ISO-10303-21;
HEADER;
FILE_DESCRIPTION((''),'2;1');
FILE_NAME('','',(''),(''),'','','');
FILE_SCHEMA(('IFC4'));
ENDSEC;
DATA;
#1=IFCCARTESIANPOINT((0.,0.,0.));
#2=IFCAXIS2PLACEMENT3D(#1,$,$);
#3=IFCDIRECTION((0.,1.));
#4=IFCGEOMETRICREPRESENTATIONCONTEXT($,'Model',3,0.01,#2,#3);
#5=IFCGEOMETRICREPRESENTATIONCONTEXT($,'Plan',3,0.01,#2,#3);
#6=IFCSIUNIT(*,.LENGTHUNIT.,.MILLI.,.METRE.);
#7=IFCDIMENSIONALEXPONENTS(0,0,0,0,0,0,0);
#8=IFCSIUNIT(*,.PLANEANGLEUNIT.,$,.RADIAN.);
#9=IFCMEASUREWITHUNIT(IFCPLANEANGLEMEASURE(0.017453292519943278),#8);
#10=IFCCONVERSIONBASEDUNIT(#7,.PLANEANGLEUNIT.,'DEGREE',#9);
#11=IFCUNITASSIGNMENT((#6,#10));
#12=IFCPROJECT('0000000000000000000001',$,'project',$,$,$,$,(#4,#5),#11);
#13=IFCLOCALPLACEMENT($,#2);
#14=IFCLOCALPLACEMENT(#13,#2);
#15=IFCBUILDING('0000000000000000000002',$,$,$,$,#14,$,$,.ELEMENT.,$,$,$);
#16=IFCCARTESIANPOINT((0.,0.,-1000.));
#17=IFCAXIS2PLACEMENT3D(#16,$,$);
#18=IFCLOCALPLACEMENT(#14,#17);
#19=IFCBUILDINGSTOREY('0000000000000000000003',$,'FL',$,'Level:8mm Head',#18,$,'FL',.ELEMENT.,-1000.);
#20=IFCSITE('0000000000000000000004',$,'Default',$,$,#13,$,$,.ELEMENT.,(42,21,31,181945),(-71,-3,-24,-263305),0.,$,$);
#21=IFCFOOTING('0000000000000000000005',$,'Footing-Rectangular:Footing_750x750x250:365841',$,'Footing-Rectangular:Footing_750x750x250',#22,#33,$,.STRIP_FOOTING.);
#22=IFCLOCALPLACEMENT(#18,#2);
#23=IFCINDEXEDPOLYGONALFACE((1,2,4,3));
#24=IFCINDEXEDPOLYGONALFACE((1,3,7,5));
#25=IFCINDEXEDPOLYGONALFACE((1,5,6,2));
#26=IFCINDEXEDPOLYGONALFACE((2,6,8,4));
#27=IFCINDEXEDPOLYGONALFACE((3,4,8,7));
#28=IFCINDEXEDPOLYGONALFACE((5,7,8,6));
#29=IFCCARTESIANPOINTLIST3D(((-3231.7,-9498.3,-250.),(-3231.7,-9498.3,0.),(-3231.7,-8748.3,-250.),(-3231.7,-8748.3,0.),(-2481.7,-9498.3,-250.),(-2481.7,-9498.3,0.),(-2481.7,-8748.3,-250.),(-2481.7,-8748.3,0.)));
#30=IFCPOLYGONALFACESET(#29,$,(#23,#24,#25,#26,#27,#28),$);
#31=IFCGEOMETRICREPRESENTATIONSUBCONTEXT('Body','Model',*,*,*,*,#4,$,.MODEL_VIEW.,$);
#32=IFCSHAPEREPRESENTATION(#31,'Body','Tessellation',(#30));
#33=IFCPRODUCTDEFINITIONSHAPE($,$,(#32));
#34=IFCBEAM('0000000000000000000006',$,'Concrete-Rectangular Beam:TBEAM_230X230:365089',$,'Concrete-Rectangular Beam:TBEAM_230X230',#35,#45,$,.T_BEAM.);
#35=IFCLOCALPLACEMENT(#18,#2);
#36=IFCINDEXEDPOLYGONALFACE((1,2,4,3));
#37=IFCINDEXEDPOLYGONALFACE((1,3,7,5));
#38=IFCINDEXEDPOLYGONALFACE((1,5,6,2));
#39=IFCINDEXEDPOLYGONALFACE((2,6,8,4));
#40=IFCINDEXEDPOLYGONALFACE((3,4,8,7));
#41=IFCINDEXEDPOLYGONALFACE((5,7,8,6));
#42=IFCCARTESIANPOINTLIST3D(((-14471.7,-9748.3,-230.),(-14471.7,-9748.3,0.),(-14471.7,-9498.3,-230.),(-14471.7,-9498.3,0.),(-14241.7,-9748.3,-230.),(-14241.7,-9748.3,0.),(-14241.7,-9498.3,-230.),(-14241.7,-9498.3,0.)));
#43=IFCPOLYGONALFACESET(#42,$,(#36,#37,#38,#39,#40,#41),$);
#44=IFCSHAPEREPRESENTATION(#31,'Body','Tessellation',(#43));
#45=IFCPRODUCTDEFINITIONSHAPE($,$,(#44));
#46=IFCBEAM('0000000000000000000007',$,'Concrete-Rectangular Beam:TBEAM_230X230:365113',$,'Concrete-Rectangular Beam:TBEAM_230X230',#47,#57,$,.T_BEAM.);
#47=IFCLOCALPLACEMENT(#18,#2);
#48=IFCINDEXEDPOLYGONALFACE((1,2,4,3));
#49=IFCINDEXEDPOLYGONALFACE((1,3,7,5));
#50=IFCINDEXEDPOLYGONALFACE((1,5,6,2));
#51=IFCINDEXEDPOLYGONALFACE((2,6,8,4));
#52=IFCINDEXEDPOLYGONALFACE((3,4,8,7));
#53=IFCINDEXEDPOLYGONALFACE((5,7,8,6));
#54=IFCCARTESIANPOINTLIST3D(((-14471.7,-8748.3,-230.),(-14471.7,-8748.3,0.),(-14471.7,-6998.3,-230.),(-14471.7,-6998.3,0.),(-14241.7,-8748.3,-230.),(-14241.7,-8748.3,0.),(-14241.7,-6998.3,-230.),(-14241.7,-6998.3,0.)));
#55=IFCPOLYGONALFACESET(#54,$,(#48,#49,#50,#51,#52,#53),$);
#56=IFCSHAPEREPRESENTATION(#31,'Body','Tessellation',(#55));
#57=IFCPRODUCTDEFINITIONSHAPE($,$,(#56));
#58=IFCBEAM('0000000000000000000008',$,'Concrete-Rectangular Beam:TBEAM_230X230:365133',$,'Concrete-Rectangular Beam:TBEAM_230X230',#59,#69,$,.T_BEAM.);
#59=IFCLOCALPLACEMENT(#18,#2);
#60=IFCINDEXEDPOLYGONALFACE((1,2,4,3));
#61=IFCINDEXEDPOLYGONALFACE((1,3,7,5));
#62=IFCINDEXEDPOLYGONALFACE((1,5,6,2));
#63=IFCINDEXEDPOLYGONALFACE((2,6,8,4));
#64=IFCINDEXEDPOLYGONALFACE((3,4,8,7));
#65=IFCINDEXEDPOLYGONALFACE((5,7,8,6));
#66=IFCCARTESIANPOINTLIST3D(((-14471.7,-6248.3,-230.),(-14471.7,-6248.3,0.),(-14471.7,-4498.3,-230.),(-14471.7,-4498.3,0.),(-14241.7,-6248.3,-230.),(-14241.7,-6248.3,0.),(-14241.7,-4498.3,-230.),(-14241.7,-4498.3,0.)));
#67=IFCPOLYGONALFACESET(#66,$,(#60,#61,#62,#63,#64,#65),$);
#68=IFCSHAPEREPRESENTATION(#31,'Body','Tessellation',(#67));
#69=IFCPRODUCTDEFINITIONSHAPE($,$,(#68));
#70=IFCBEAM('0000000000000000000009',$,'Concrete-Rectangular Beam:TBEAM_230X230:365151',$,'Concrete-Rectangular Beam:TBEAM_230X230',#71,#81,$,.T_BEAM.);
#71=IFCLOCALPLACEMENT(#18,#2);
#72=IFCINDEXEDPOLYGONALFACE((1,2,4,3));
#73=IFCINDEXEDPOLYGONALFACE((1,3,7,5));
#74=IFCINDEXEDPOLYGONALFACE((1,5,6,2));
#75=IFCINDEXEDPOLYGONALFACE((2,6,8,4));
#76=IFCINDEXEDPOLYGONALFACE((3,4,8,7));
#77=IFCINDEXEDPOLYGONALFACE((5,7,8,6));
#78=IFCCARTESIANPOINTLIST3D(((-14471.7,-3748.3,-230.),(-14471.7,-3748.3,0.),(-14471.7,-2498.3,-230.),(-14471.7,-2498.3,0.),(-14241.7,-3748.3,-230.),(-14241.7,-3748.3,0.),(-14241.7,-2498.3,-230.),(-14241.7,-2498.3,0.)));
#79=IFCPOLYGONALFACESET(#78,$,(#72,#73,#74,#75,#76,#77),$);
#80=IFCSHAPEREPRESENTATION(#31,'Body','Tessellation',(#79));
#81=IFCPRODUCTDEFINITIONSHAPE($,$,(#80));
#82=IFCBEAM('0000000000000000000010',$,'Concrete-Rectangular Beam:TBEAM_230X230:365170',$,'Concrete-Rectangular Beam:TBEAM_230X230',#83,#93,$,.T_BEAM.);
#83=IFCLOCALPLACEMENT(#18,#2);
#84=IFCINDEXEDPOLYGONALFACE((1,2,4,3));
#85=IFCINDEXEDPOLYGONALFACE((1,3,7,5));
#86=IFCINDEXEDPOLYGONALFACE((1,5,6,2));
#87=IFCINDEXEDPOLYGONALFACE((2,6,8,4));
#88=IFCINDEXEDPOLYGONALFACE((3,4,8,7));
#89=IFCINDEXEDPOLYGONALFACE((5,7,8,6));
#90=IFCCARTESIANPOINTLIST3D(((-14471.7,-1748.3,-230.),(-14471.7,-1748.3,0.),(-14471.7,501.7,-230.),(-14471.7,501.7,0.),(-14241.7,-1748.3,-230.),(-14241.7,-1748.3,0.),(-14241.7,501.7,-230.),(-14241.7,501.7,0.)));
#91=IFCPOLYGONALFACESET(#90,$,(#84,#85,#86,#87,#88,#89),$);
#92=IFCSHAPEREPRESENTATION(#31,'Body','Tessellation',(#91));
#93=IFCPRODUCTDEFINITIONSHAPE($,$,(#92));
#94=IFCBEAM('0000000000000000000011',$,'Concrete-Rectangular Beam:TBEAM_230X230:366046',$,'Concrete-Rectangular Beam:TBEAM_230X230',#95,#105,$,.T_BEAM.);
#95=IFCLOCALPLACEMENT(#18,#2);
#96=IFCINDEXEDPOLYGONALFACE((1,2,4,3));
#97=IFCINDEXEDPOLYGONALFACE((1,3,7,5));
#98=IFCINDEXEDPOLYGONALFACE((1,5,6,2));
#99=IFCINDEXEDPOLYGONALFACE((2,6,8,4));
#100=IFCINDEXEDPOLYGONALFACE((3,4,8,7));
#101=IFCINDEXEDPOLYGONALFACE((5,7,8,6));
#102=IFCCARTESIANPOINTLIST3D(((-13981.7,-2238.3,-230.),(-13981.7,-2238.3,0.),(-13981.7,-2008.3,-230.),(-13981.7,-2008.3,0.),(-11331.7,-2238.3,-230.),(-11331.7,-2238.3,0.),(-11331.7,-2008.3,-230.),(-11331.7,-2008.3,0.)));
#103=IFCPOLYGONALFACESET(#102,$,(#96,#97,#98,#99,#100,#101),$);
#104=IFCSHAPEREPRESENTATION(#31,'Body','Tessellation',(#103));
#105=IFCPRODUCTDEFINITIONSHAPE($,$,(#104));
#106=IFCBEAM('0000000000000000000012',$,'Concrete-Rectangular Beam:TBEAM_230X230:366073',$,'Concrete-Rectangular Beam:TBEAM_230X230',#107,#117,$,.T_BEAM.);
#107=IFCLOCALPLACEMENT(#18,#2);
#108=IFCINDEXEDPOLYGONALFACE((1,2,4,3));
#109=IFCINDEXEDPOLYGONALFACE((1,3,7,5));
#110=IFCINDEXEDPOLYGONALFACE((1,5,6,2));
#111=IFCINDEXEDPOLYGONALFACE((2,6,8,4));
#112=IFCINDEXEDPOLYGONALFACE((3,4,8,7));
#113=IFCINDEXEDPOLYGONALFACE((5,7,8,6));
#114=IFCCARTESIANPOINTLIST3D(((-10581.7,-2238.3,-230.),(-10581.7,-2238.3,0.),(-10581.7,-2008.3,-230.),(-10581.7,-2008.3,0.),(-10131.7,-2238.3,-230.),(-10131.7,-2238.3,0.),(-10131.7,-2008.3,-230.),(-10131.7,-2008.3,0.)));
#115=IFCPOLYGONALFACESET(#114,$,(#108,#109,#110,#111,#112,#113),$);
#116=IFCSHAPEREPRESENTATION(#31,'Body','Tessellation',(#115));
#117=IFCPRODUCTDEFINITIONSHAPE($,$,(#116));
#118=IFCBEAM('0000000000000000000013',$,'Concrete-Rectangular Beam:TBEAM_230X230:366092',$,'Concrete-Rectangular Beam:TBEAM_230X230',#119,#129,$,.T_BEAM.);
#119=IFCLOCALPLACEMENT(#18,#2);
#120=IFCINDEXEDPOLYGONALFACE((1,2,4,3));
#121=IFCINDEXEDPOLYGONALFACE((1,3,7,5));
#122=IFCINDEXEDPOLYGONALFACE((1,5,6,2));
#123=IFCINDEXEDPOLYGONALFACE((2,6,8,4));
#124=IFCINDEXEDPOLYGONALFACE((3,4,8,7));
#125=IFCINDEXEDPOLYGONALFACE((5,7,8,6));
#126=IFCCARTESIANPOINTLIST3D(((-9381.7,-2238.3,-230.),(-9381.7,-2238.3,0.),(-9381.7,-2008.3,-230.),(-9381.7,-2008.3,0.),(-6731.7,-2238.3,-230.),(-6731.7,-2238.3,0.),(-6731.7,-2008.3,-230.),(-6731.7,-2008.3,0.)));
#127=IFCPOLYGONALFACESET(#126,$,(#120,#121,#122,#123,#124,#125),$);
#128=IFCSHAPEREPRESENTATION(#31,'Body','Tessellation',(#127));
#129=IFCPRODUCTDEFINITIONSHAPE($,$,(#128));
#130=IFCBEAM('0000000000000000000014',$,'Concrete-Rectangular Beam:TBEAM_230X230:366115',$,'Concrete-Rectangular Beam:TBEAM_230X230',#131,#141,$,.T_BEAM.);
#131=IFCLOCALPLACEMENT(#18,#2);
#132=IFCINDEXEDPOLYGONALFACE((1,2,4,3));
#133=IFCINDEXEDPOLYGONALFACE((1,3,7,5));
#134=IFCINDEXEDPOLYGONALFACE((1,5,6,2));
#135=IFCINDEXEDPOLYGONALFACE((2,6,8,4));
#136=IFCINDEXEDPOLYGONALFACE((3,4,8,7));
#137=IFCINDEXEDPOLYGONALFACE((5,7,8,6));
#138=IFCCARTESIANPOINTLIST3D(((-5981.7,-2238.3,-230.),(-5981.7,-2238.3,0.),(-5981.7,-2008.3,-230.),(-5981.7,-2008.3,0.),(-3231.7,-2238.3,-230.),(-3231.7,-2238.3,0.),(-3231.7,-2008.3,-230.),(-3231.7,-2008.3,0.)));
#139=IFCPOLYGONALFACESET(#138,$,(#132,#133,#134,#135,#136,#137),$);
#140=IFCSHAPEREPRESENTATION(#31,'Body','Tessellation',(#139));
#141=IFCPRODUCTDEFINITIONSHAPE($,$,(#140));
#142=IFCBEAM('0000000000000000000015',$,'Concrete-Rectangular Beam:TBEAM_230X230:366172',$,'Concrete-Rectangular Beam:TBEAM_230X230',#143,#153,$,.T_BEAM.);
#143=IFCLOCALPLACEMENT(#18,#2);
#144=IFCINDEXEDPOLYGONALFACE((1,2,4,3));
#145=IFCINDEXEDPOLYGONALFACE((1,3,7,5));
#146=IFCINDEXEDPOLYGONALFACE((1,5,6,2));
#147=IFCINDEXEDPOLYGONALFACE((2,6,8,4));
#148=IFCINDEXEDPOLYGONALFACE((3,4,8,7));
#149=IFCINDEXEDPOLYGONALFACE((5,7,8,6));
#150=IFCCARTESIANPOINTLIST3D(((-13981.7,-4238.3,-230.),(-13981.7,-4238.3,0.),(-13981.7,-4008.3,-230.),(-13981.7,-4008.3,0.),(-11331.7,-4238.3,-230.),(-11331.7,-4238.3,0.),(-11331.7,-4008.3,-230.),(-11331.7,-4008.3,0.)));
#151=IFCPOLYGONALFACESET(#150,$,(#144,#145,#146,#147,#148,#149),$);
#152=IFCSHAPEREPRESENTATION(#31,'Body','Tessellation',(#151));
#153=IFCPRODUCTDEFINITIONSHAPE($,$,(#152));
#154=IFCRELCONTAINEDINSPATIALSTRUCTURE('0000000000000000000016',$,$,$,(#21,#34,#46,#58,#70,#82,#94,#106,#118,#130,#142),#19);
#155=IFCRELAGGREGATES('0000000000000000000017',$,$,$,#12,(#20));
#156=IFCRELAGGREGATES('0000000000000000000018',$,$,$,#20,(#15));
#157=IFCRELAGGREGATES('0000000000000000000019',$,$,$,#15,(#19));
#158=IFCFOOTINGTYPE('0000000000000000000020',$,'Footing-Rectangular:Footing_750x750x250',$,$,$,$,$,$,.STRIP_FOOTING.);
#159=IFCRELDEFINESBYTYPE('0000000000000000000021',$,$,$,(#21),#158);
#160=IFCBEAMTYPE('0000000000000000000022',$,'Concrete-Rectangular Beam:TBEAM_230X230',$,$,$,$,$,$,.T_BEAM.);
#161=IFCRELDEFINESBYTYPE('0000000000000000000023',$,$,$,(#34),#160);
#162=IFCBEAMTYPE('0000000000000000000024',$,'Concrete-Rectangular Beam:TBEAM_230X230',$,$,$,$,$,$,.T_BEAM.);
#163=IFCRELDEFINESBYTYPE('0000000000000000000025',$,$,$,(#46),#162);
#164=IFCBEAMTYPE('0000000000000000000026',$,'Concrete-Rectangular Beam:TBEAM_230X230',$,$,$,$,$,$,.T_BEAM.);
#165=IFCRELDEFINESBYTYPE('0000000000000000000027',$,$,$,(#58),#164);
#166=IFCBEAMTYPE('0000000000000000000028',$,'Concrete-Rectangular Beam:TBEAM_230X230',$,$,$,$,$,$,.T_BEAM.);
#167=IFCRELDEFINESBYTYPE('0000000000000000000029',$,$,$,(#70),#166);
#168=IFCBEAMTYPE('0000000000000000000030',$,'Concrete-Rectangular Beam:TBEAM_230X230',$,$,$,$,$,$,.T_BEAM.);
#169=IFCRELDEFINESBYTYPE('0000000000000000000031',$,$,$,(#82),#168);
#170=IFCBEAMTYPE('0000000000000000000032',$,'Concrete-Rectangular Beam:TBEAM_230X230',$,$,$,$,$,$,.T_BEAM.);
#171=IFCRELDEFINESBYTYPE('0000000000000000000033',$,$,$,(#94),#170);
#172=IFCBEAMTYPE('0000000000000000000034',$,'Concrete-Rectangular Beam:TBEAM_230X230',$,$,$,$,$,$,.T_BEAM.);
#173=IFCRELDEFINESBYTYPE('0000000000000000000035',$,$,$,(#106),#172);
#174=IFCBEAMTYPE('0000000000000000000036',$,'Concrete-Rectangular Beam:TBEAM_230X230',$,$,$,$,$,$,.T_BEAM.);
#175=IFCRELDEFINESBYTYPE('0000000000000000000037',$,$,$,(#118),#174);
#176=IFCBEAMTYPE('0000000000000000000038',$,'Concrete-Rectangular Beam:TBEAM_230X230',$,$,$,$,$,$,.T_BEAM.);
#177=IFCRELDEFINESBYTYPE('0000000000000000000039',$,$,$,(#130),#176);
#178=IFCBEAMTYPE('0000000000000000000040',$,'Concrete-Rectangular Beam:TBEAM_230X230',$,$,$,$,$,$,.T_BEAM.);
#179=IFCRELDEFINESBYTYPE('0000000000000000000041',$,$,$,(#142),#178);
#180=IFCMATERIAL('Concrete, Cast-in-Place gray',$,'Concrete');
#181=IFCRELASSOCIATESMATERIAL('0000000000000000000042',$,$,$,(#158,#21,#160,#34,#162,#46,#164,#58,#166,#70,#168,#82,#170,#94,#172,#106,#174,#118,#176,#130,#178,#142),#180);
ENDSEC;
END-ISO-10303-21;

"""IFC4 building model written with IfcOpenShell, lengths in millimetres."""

from ifc_helpers import new_model, entity, si_unit, converted_unit, direction, frame, origin, place, context, subcontext, project, spatial, indexed_curve, outline, extrude, source, transform, mapped, material, type_object, type_shapes, element, save


model = new_model("IFC4")

# Units and contexts
model_context = context("Model", 3, precision=0.01, world=origin(), true_north=direction((0.0, 1.0)))
plan_context = context("Plan", 3, precision=0.01, world=origin(), true_north=direction((0.0, 1.0)))
body_context = subcontext(model_context, "Body", "Model", "MODEL_VIEW")
ifc_project = project(units=[si_unit("LENGTHUNIT", "METRE", prefix="MILLI"), converted_unit("PLANEANGLEUNIT", "DEGREE", entity("IfcPlaneAngleMeasure", 0.017453292519943278), si_unit("PLANEANGLEUNIT", "RADIAN"), dimensions=[0, 0, 0, 0, 0, 0, 0])], contexts=[model_context, plan_context])

# Site, building, storey
site_placement = place(None, origin())
site = spatial("IfcSite", under=ifc_project, at=site_placement, Name="Default", CompositionType="ELEMENT", RefLatitude=(42, 21, 31, 181945), RefLongitude=(-71, -3, -24, -263305), RefElevation=0.0)
building_placement = place(site_placement, origin())
building = spatial("IfcBuilding", under=site, at=building_placement, CompositionType="ELEMENT")
storey_placement = place(building_placement, frame((0.0, 0.0, -1000.0)))
storey = spatial("IfcBuildingStorey", under=building, at=storey_placement, Name="FL", ObjectType="Level:8mm Head", LongName="FL", CompositionType="ELEMENT", Elevation=-1000.0)

# Footing
ifc_material = material(Name="Concrete, Cast-in-Place gray", Category="Concrete")
footing_type = type_object("IfcFootingType", Name="Footing-Rectangular:Footing_750x750x250", PredefinedType="STRIP_FOOTING", material=ifc_material)
shared_shape_1 = source(origin(), body_context, "Body", "SweptSolid", [
    extrude(outline(indexed_curve([(-375.0, -375.0), (375.0, -375.0), (375.0, 375.0), (-375.0, 375.0), (-375.0, -375.0)], self_intersect=False)), frame((-2856.7, -9123.3, -1250.0), z_axis=(0.0, 0.0, 1.0), x_axis=(-1.0, 0.0, 0.0)), (0.0, 0.0, 1.0), 250.0),
])
type_shapes(footing_type, [shared_shape_1])
footing_placement = place(storey_placement, frame((0.0, 0.0, 1000.0)))
element("IfcFooting", 1, at=footing_placement, inside=storey, type_object=footing_type, material=ifc_material, Name="Footing-Rectangular:Footing_750x750x250:365841", ObjectType="Footing-Rectangular:Footing_750x750x250", PredefinedType="STRIP_FOOTING", context=body_context, shape_type="MappedRepresentation", body=[
    mapped(shared_shape_1, transform((0.0, 0.0, 0.0), scale=1.0)),
])

# Beams
beam_type_1 = type_object("IfcBeamType", Name="Concrete-Rectangular Beam:TBEAM_230X230", PredefinedType="T_BEAM", material=ifc_material)
shared_shape_2 = source(origin(), body_context, "Body", "SweptSolid", [
    extrude(outline(indexed_curve([(-115.0, -115.0), (115.0, -115.0), (115.0, 115.0), (-115.0, 115.0), (-115.0, -115.0)], self_intersect=False)), frame((-14356.7, -9748.3, -1115.0), z_axis=(0.0, 1.0, 0.0), x_axis=(-1.0, 0.0, 0.0)), (0.0, 0.0, 1.0), 250.0),
])
type_shapes(beam_type_1, [shared_shape_2])
beam_1_placement = place(storey_placement, frame((0.0, 0.0, 1000.0)))
element("IfcBeam", 2, at=beam_1_placement, inside=storey, type_object=beam_type_1, material=ifc_material, Name="Concrete-Rectangular Beam:TBEAM_230X230:365089", ObjectType="Concrete-Rectangular Beam:TBEAM_230X230", PredefinedType="T_BEAM", context=body_context, shape_type="MappedRepresentation", body=[
    mapped(shared_shape_2, transform((0.0, 0.0, 0.0), scale=1.0)),
])
beam_type_2 = type_object("IfcBeamType", Name="Concrete-Rectangular Beam:TBEAM_230X230", PredefinedType="T_BEAM", material=ifc_material)
shared_shape_3 = source(origin(), body_context, "Body", "SweptSolid", [
    extrude(outline(indexed_curve([(-115.0, -115.0), (115.0, -115.0), (115.0, 115.0), (-115.0, 115.0), (-115.0, -115.0)], self_intersect=False)), frame((-14356.7, -8748.3, -1115.0), z_axis=(0.0, 1.0, 0.0), x_axis=(-1.0, 0.0, 0.0)), (0.0, 0.0, 1.0), 1750.0),
])
type_shapes(beam_type_2, [shared_shape_3])
beam_2_placement = place(storey_placement, frame((0.0, 0.0, 1000.0)))
element("IfcBeam", 3, at=beam_2_placement, inside=storey, type_object=beam_type_2, material=ifc_material, Name="Concrete-Rectangular Beam:TBEAM_230X230:365113", ObjectType="Concrete-Rectangular Beam:TBEAM_230X230", PredefinedType="T_BEAM", context=body_context, shape_type="MappedRepresentation", body=[
    mapped(shared_shape_3, transform((0.0, 0.0, 0.0), scale=1.0)),
])
beam_type_3 = type_object("IfcBeamType", Name="Concrete-Rectangular Beam:TBEAM_230X230", PredefinedType="T_BEAM", material=ifc_material)
shared_shape_4 = source(origin(), body_context, "Body", "SweptSolid", [
    extrude(outline(indexed_curve([(-115.0, -115.0), (115.0, -115.0), (115.0, 115.0), (-115.0, 115.0), (-115.0, -115.0)], self_intersect=False)), frame((-14356.7, -6248.3, -1115.0), z_axis=(0.0, 1.0, 0.0), x_axis=(-1.0, 0.0, 0.0)), (0.0, 0.0, 1.0), 1750.0),
])
type_shapes(beam_type_3, [shared_shape_4])
beam_3_placement = place(storey_placement, frame((0.0, 0.0, 1000.0)))
element("IfcBeam", 4, at=beam_3_placement, inside=storey, type_object=beam_type_3, material=ifc_material, Name="Concrete-Rectangular Beam:TBEAM_230X230:365133", ObjectType="Concrete-Rectangular Beam:TBEAM_230X230", PredefinedType="T_BEAM", context=body_context, shape_type="MappedRepresentation", body=[
    mapped(shared_shape_4, transform((0.0, 0.0, 0.0), scale=1.0)),
])
beam_type_4 = type_object("IfcBeamType", Name="Concrete-Rectangular Beam:TBEAM_230X230", PredefinedType="T_BEAM", material=ifc_material)
shared_shape_5 = source(origin(), body_context, "Body", "SweptSolid", [
    extrude(outline(indexed_curve([(-115.0, -115.0), (115.0, -115.0), (115.0, 115.0), (-115.0, 115.0), (-115.0, -115.0)], self_intersect=False)), frame((-14356.7, -3748.3, -1115.0), z_axis=(0.0, 1.0, 0.0), x_axis=(-1.0, 0.0, 0.0)), (0.0, 0.0, 1.0), 1250.0),
])
type_shapes(beam_type_4, [shared_shape_5])
beam_4_placement = place(storey_placement, frame((0.0, 0.0, 1000.0)))
element("IfcBeam", 5, at=beam_4_placement, inside=storey, type_object=beam_type_4, material=ifc_material, Name="Concrete-Rectangular Beam:TBEAM_230X230:365151", ObjectType="Concrete-Rectangular Beam:TBEAM_230X230", PredefinedType="T_BEAM", context=body_context, shape_type="MappedRepresentation", body=[
    mapped(shared_shape_5, transform((0.0, 0.0, 0.0), scale=1.0)),
])
beam_type_5 = type_object("IfcBeamType", Name="Concrete-Rectangular Beam:TBEAM_230X230", PredefinedType="T_BEAM", material=ifc_material)
shared_shape_6 = source(origin(), body_context, "Body", "SweptSolid", [
    extrude(outline(indexed_curve([(-115.0, -115.0), (115.0, -115.0), (115.0, 115.0), (-115.0, 115.0), (-115.0, -115.0)], self_intersect=False)), frame((-14356.7, -1748.3, -1115.0), z_axis=(0.0, 1.0, 0.0), x_axis=(-1.0, 0.0, 0.0)), (0.0, 0.0, 1.0), 2250.0),
])
type_shapes(beam_type_5, [shared_shape_6])
beam_5_placement = place(storey_placement, frame((0.0, 0.0, 1000.0)))
element("IfcBeam", 6, at=beam_5_placement, inside=storey, type_object=beam_type_5, material=ifc_material, Name="Concrete-Rectangular Beam:TBEAM_230X230:365170", ObjectType="Concrete-Rectangular Beam:TBEAM_230X230", PredefinedType="T_BEAM", context=body_context, shape_type="MappedRepresentation", body=[
    mapped(shared_shape_6, transform((0.0, 0.0, 0.0), scale=1.0)),
])
beam_type_6 = type_object("IfcBeamType", Name="Concrete-Rectangular Beam:TBEAM_230X230", PredefinedType="T_BEAM", material=ifc_material)
shared_shape_7 = source(origin(), body_context, "Body", "SweptSolid", [
    extrude(outline(indexed_curve([(-115.0, -115.0), (115.0, -115.0), (115.0, 115.0), (-115.0, 115.0), (-115.0, -115.0)], self_intersect=False)), frame((-13981.7, -2123.3, -1115.0), z_axis=(1.0, 0.0, 0.0), x_axis=(0.0, 0.0, -1.0)), (0.0, 0.0, 1.0), 2650.0),
])
type_shapes(beam_type_6, [shared_shape_7])
beam_6_placement = place(storey_placement, frame((0.0, 0.0, 1000.0)))
element("IfcBeam", 7, at=beam_6_placement, inside=storey, type_object=beam_type_6, material=ifc_material, Name="Concrete-Rectangular Beam:TBEAM_230X230:366046", ObjectType="Concrete-Rectangular Beam:TBEAM_230X230", PredefinedType="T_BEAM", context=body_context, shape_type="MappedRepresentation", body=[
    mapped(shared_shape_7, transform((0.0, 0.0, 0.0), scale=1.0)),
])
beam_type_7 = type_object("IfcBeamType", Name="Concrete-Rectangular Beam:TBEAM_230X230", PredefinedType="T_BEAM", material=ifc_material)
shared_shape_8 = source(origin(), body_context, "Body", "SweptSolid", [
    extrude(outline(indexed_curve([(-115.0, -115.0), (115.0, -115.0), (115.0, 115.0), (-115.0, 115.0), (-115.0, -115.0)], self_intersect=False)), frame((-10581.7, -2123.3, -1115.0), z_axis=(1.0, 0.0, 0.0), x_axis=(0.0, 0.0, -1.0)), (0.0, 0.0, 1.0), 450.0),
])
type_shapes(beam_type_7, [shared_shape_8])
beam_7_placement = place(storey_placement, frame((0.0, 0.0, 1000.0)))
element("IfcBeam", 8, at=beam_7_placement, inside=storey, type_object=beam_type_7, material=ifc_material, Name="Concrete-Rectangular Beam:TBEAM_230X230:366073", ObjectType="Concrete-Rectangular Beam:TBEAM_230X230", PredefinedType="T_BEAM", context=body_context, shape_type="MappedRepresentation", body=[
    mapped(shared_shape_8, transform((0.0, 0.0, 0.0), scale=1.0)),
])
beam_type_8 = type_object("IfcBeamType", Name="Concrete-Rectangular Beam:TBEAM_230X230", PredefinedType="T_BEAM", material=ifc_material)
shared_shape_9 = source(origin(), body_context, "Body", "SweptSolid", [
    extrude(outline(indexed_curve([(-115.0, -115.0), (115.0, -115.0), (115.0, 115.0), (-115.0, 115.0), (-115.0, -115.0)], self_intersect=False)), frame((-9381.7, -2123.3, -1115.0), z_axis=(1.0, 0.0, 0.0), x_axis=(0.0, 0.0, -1.0)), (0.0, 0.0, 1.0), 2650.0),
])
type_shapes(beam_type_8, [shared_shape_9])
beam_8_placement = place(storey_placement, frame((0.0, 0.0, 1000.0)))
element("IfcBeam", 9, at=beam_8_placement, inside=storey, type_object=beam_type_8, material=ifc_material, Name="Concrete-Rectangular Beam:TBEAM_230X230:366092", ObjectType="Concrete-Rectangular Beam:TBEAM_230X230", PredefinedType="T_BEAM", context=body_context, shape_type="MappedRepresentation", body=[
    mapped(shared_shape_9, transform((0.0, 0.0, 0.0), scale=1.0)),
])
beam_type_9 = type_object("IfcBeamType", Name="Concrete-Rectangular Beam:TBEAM_230X230", PredefinedType="T_BEAM", material=ifc_material)
shared_shape_10 = source(origin(), body_context, "Body", "SweptSolid", [
    extrude(outline(indexed_curve([(-115.0, -115.0), (115.0, -115.0), (115.0, 115.0), (-115.0, 115.0), (-115.0, -115.0)], self_intersect=False)), frame((-5981.7, -2123.3, -1115.0), z_axis=(1.0, 0.0, 0.0), x_axis=(0.0, 0.0, -1.0)), (0.0, 0.0, 1.0), 2750.0),
])
type_shapes(beam_type_9, [shared_shape_10])
beam_9_placement = place(storey_placement, frame((0.0, 0.0, 1000.0)))
element("IfcBeam", 10, at=beam_9_placement, inside=storey, type_object=beam_type_9, material=ifc_material, Name="Concrete-Rectangular Beam:TBEAM_230X230:366115", ObjectType="Concrete-Rectangular Beam:TBEAM_230X230", PredefinedType="T_BEAM", context=body_context, shape_type="MappedRepresentation", body=[
    mapped(shared_shape_10, transform((0.0, 0.0, 0.0), scale=1.0)),
])
beam_type_10 = type_object("IfcBeamType", Name="Concrete-Rectangular Beam:TBEAM_230X230", PredefinedType="T_BEAM", material=ifc_material)
shared_shape_11 = source(origin(), body_context, "Body", "SweptSolid", [
    extrude(outline(indexed_curve([(-115.0, -115.0), (115.0, -115.0), (115.0, 115.0), (-115.0, 115.0), (-115.0, -115.0)], self_intersect=False)), frame((-13981.7, -4123.3, -1115.0), z_axis=(1.0, 0.0, 0.0), x_axis=(0.0, 0.0, -1.0)), (0.0, 0.0, 1.0), 2650.0),
])
type_shapes(beam_type_10, [shared_shape_11])
beam_10_placement = place(storey_placement, frame((0.0, 0.0, 1000.0)))
element("IfcBeam", 11, at=beam_10_placement, inside=storey, type_object=beam_type_10, material=ifc_material, Name="Concrete-Rectangular Beam:TBEAM_230X230:366172", ObjectType="Concrete-Rectangular Beam:TBEAM_230X230", PredefinedType="T_BEAM", context=body_context, shape_type="MappedRepresentation", body=[
    mapped(shared_shape_11, transform((0.0, 0.0, 0.0), scale=1.0)),
])

save(model, "model.ifc")
